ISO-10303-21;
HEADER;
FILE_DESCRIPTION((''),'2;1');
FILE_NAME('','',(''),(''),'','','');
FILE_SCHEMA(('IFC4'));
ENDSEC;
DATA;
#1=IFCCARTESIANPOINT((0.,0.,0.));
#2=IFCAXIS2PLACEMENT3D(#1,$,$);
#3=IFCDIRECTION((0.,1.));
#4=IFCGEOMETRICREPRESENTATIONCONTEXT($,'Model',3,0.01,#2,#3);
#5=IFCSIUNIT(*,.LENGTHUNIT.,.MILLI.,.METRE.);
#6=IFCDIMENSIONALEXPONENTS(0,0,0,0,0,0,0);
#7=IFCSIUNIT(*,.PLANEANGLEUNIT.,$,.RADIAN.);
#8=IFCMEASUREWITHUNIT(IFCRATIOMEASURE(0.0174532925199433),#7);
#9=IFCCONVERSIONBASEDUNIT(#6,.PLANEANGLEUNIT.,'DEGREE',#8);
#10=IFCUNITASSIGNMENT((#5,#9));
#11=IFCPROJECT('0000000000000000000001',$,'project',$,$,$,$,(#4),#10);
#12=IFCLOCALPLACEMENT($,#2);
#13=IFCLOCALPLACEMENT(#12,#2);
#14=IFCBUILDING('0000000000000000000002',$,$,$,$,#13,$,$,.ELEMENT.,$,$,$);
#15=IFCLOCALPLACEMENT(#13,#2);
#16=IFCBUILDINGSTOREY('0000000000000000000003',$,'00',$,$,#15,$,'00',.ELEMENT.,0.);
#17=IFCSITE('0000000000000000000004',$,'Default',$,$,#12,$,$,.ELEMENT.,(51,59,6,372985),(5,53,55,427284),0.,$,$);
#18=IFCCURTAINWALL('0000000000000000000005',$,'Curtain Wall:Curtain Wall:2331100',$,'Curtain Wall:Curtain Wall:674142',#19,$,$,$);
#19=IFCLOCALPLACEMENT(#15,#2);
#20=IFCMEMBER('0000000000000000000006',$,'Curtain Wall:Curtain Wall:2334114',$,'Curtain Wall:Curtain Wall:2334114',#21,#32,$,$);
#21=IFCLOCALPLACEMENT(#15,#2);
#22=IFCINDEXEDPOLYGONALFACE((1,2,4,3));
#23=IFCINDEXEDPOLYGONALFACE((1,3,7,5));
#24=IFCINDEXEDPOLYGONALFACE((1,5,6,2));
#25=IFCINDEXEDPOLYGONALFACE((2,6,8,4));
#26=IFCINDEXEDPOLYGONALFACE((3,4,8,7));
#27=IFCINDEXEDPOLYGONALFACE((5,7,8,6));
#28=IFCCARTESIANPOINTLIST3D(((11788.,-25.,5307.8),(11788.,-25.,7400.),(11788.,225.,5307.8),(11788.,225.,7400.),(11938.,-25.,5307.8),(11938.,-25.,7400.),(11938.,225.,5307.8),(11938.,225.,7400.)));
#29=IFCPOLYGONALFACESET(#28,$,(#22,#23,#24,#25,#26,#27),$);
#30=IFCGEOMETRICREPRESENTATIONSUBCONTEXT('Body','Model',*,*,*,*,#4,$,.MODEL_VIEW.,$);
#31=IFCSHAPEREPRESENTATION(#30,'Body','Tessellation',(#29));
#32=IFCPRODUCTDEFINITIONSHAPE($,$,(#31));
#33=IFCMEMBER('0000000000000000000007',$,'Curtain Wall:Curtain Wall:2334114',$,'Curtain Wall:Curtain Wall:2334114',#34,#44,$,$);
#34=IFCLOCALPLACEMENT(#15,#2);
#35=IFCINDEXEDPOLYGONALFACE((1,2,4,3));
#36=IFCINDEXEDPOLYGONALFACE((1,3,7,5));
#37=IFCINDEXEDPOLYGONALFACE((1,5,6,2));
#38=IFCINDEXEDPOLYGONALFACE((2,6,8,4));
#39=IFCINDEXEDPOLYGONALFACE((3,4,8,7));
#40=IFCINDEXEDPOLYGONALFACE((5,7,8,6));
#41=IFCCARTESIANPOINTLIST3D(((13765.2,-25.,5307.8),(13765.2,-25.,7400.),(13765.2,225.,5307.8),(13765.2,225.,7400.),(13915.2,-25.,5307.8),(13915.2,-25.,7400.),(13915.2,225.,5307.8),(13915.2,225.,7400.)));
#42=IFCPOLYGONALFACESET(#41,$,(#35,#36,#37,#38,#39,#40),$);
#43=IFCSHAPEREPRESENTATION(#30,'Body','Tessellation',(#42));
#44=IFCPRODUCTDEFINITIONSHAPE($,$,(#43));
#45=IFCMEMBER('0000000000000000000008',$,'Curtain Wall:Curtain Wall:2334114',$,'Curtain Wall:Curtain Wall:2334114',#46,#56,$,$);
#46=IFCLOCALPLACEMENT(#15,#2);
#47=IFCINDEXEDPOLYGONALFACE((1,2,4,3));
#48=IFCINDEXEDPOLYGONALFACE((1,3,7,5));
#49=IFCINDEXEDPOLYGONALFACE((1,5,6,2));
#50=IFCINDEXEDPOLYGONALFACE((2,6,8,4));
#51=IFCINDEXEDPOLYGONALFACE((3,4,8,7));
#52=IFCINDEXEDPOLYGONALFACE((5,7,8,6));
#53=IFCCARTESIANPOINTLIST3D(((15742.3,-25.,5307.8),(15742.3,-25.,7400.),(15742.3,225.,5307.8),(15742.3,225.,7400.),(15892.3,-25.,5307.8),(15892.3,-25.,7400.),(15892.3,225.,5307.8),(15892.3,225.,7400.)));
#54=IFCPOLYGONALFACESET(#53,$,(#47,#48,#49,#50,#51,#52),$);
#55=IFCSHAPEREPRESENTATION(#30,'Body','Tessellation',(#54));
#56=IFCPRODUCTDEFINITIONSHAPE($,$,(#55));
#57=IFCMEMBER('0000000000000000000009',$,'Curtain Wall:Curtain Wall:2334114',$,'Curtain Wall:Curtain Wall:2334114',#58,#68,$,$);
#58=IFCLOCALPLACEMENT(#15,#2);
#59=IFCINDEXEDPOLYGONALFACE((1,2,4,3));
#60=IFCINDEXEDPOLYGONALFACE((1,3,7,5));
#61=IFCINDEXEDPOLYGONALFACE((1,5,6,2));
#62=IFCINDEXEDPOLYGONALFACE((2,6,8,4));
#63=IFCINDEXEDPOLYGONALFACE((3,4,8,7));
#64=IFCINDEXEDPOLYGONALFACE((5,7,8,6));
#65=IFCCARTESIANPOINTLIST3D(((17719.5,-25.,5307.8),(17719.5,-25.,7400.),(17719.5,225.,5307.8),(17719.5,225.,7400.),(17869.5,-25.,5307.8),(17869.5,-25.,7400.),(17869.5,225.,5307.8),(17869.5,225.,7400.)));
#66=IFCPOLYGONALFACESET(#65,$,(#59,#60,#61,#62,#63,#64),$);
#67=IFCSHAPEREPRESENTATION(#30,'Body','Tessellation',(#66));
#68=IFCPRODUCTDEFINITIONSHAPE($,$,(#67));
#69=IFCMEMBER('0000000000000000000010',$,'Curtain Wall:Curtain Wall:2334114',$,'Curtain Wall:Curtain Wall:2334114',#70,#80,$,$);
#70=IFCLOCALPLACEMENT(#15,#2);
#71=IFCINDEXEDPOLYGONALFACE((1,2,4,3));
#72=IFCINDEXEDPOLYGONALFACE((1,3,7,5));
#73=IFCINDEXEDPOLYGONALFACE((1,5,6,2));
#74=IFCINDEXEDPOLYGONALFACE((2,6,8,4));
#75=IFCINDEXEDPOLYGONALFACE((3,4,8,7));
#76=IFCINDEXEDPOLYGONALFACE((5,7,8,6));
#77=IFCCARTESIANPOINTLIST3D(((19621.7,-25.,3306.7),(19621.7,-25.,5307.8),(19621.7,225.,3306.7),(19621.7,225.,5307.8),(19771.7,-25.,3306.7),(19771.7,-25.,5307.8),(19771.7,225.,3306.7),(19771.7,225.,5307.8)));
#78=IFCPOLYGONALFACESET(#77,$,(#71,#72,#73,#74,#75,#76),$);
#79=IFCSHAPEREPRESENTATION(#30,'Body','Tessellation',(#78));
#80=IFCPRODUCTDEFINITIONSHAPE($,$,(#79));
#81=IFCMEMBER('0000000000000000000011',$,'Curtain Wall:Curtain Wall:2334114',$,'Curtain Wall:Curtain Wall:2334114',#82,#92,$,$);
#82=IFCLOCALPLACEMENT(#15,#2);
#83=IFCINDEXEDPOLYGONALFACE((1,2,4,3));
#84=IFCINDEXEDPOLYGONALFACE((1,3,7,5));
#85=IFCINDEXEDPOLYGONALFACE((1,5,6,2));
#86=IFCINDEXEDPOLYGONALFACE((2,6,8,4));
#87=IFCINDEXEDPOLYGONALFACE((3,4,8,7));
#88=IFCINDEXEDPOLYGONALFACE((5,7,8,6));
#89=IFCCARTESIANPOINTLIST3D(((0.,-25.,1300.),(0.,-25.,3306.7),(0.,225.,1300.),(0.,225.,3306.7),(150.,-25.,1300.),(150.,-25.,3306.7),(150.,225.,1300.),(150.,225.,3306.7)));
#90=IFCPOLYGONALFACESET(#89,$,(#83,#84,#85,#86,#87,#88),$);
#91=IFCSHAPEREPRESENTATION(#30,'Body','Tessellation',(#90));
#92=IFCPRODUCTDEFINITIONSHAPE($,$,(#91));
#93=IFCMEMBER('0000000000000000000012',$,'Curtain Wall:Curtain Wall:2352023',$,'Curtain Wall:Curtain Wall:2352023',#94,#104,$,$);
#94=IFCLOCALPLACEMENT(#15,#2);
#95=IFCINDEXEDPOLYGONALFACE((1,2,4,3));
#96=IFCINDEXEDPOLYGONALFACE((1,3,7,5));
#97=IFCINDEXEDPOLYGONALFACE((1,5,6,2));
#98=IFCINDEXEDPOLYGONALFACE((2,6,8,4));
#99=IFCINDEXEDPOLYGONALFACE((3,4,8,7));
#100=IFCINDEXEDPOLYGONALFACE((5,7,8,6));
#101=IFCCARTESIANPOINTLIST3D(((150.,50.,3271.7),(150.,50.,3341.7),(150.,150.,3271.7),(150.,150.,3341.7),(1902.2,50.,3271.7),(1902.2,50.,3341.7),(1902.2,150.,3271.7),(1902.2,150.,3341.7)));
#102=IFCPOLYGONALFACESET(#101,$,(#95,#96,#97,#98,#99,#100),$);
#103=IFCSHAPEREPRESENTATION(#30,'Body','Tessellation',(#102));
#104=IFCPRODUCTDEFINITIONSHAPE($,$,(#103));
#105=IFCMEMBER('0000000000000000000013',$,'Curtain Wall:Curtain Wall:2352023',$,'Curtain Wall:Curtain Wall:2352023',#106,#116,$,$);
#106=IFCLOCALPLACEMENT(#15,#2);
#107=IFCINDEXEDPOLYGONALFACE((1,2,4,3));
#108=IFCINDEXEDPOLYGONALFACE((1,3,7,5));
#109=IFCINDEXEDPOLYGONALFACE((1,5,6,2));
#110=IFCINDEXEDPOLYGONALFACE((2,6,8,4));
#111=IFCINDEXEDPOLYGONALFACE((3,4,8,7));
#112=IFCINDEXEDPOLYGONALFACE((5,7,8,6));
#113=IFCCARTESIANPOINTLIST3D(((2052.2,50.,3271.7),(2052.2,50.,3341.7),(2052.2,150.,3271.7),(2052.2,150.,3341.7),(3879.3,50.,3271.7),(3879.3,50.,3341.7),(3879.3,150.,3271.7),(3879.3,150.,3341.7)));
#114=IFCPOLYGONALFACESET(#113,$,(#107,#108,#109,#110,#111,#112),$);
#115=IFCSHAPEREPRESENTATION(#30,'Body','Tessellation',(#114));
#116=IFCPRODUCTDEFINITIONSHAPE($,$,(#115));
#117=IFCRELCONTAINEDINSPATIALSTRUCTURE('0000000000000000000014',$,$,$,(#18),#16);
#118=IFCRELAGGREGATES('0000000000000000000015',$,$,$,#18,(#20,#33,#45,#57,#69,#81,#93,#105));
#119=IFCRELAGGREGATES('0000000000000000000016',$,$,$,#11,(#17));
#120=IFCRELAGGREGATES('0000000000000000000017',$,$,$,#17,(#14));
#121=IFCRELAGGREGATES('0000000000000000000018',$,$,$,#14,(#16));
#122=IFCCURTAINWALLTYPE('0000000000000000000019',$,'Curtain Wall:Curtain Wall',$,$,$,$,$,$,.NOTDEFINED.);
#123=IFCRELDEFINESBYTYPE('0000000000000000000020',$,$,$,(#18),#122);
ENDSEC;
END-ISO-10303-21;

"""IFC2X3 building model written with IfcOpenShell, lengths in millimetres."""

from ifc_helpers import new_model, entity, si_unit, converted_unit, direction, frame, frame_2d, origin, origin_2d_with_axis, place, context, subcontext, project, spatial, rectangle, extrude, type_object, element, aggregate, save


model = new_model("IFC2X3")

# Units and contexts
model_context = context("Model", 3, precision=0.01, world=origin(), true_north=direction((0.0, 1.0)))
body_context = subcontext(model_context, "Body", "Model", "MODEL_VIEW")
ifc_project = project(units=[si_unit("LENGTHUNIT", "METRE", prefix="MILLI"), converted_unit("PLANEANGLEUNIT", "DEGREE", entity("IfcRatioMeasure", 0.0174532925199433), si_unit("PLANEANGLEUNIT", "RADIAN"), dimensions=[0, 0, 0, 0, 0, 0, 0])], contexts=[model_context])

# Site, building, storey
site_placement = place(None, origin())
site = spatial("IfcSite", under=ifc_project, at=site_placement, Name="Default", CompositionType="ELEMENT", RefLatitude=(51, 59, 6, 372985), RefLongitude=(5, 53, 55, 427284), RefElevation=0.0)
building_placement = place(site_placement, origin())
building = spatial("IfcBuilding", under=site, at=building_placement, CompositionType="ELEMENT")
storey_placement = place(building_placement, origin())
storey = spatial("IfcBuildingStorey", under=building, at=storey_placement, Name="00", LongName="00", CompositionType="ELEMENT", Elevation=0.0)

# Curtain wall, members
curtain_wall_type = type_object("IfcCurtainWallType", Name="Curtain Wall:Curtain Wall", PredefinedType="NOTDEFINED")
curtain_wall_placement = place(storey_placement, origin())
curtain_wall = element("IfcCurtainWall", 1, at=curtain_wall_placement, inside=storey, type_object=curtain_wall_type, Name="Curtain Wall:Curtain Wall:2331100", ObjectType="Curtain Wall:Curtain Wall:674142")
member_1_placement = place(curtain_wall_placement, origin())
member_1 = element("IfcMember", 2, at=member_1_placement, Name="Curtain Wall:Curtain Wall:2334114", ObjectType="Curtain Wall:Curtain Wall:2334114", context=body_context, shape_type="SweptSolid", body=[
    extrude(rectangle(XDim=150.0, YDim=250.0, at=origin_2d_with_axis()), frame((11863.0, 100.0, 5307.8), z_axis=(0.0, 0.0, 1.0), x_axis=(-1.0, 0.0, 0.0)), (0.0, 0.0, 1.0), 2092.2),
])
member_2_placement = place(curtain_wall_placement, origin())
member_2 = element("IfcMember", 3, at=member_2_placement, Name="Curtain Wall:Curtain Wall:2334114", ObjectType="Curtain Wall:Curtain Wall:2334114", context=body_context, shape_type="SweptSolid", body=[
    extrude(rectangle(XDim=150.0, YDim=250.0, at=frame_2d((0.0, 0.0), x_axis=(1.0, 0.0))), frame((13840.2, 100.0, 5307.8), z_axis=(0.0, 0.0, 1.0), x_axis=(-1.0, 0.0, 0.0)), (0.0, 0.0, 1.0), 2092.2),
])
member_3_placement = place(curtain_wall_placement, origin())
member_3 = element("IfcMember", 4, at=member_3_placement, Name="Curtain Wall:Curtain Wall:2334114", ObjectType="Curtain Wall:Curtain Wall:2334114", context=body_context, shape_type="SweptSolid", body=[
    extrude(rectangle(XDim=150.0, YDim=250.0, at=origin_2d_with_axis()), frame((15817.3, 100.0, 5307.8), z_axis=(0.0, 0.0, 1.0), x_axis=(-1.0, 0.0, 0.0)), (0.0, 0.0, 1.0), 2092.2),
])
member_4_placement = place(curtain_wall_placement, origin())
member_4 = element("IfcMember", 5, at=member_4_placement, Name="Curtain Wall:Curtain Wall:2334114", ObjectType="Curtain Wall:Curtain Wall:2334114", context=body_context, shape_type="SweptSolid", body=[
    extrude(rectangle(XDim=150.0, YDim=250.0, at=origin_2d_with_axis()), frame((17794.5, 100.0, 5307.8), z_axis=(0.0, 0.0, 1.0), x_axis=(-1.0, 0.0, 0.0)), (0.0, 0.0, 1.0), 2092.2),
])
member_5_placement = place(curtain_wall_placement, origin())
member_5 = element("IfcMember", 6, at=member_5_placement, Name="Curtain Wall:Curtain Wall:2334114", ObjectType="Curtain Wall:Curtain Wall:2334114", context=body_context, shape_type="SweptSolid", body=[
    extrude(rectangle(XDim=150.0, YDim=250.0, at=origin_2d_with_axis()), frame((19696.7, 100.0, 3306.7), z_axis=(0.0, 0.0, 1.0), x_axis=(-1.0, 0.0, 0.0)), (0.0, 0.0, 1.0), 2001.1),
])
member_6_placement = place(curtain_wall_placement, origin())
member_6 = element("IfcMember", 7, at=member_6_placement, Name="Curtain Wall:Curtain Wall:2334114", ObjectType="Curtain Wall:Curtain Wall:2334114", context=body_context, shape_type="SweptSolid", body=[
    extrude(rectangle(XDim=150.0, YDim=250.0, at=origin_2d_with_axis()), frame((75.0, 100.0, 3306.7), z_axis=(0.0, 0.0, -1.0), x_axis=(-1.0, 0.0, 0.0)), (0.0, 0.0, 1.0), 2006.7),
])
member_7_placement = place(curtain_wall_placement, origin())
member_7 = element("IfcMember", 8, at=member_7_placement, Name="Curtain Wall:Curtain Wall:2352023", ObjectType="Curtain Wall:Curtain Wall:2352023", context=body_context, shape_type="SweptSolid", body=[
    extrude(rectangle(XDim=70.0, YDim=100.0, at=frame_2d((0.0, 0.0), x_axis=(1.0, 0.0))), frame((1902.2, 100.0, 3306.7), z_axis=(-1.0, 0.0, 0.0), x_axis=(0.0, 0.0, -1.0)), (0.0, 0.0, 1.0), 1752.2),
])
member_8_placement = place(curtain_wall_placement, origin())
member_8 = element("IfcMember", 9, at=member_8_placement, Name="Curtain Wall:Curtain Wall:2352023", ObjectType="Curtain Wall:Curtain Wall:2352023", context=body_context, shape_type="SweptSolid", body=[
    extrude(rectangle(XDim=70.0, YDim=100.0, at=frame_2d((0.0, 0.0), x_axis=(1.0, 0.0))), frame((3879.3, 100.0, 3306.7), z_axis=(-1.0, 0.0, 0.0), x_axis=(0.0, 0.0, -1.0)), (0.0, 0.0, 1.0), 1827.2),
])
aggregate(curtain_wall, [member_1, member_2, member_3, member_4, member_5, member_6, member_7, member_8])

save(model, "model.ifc")
